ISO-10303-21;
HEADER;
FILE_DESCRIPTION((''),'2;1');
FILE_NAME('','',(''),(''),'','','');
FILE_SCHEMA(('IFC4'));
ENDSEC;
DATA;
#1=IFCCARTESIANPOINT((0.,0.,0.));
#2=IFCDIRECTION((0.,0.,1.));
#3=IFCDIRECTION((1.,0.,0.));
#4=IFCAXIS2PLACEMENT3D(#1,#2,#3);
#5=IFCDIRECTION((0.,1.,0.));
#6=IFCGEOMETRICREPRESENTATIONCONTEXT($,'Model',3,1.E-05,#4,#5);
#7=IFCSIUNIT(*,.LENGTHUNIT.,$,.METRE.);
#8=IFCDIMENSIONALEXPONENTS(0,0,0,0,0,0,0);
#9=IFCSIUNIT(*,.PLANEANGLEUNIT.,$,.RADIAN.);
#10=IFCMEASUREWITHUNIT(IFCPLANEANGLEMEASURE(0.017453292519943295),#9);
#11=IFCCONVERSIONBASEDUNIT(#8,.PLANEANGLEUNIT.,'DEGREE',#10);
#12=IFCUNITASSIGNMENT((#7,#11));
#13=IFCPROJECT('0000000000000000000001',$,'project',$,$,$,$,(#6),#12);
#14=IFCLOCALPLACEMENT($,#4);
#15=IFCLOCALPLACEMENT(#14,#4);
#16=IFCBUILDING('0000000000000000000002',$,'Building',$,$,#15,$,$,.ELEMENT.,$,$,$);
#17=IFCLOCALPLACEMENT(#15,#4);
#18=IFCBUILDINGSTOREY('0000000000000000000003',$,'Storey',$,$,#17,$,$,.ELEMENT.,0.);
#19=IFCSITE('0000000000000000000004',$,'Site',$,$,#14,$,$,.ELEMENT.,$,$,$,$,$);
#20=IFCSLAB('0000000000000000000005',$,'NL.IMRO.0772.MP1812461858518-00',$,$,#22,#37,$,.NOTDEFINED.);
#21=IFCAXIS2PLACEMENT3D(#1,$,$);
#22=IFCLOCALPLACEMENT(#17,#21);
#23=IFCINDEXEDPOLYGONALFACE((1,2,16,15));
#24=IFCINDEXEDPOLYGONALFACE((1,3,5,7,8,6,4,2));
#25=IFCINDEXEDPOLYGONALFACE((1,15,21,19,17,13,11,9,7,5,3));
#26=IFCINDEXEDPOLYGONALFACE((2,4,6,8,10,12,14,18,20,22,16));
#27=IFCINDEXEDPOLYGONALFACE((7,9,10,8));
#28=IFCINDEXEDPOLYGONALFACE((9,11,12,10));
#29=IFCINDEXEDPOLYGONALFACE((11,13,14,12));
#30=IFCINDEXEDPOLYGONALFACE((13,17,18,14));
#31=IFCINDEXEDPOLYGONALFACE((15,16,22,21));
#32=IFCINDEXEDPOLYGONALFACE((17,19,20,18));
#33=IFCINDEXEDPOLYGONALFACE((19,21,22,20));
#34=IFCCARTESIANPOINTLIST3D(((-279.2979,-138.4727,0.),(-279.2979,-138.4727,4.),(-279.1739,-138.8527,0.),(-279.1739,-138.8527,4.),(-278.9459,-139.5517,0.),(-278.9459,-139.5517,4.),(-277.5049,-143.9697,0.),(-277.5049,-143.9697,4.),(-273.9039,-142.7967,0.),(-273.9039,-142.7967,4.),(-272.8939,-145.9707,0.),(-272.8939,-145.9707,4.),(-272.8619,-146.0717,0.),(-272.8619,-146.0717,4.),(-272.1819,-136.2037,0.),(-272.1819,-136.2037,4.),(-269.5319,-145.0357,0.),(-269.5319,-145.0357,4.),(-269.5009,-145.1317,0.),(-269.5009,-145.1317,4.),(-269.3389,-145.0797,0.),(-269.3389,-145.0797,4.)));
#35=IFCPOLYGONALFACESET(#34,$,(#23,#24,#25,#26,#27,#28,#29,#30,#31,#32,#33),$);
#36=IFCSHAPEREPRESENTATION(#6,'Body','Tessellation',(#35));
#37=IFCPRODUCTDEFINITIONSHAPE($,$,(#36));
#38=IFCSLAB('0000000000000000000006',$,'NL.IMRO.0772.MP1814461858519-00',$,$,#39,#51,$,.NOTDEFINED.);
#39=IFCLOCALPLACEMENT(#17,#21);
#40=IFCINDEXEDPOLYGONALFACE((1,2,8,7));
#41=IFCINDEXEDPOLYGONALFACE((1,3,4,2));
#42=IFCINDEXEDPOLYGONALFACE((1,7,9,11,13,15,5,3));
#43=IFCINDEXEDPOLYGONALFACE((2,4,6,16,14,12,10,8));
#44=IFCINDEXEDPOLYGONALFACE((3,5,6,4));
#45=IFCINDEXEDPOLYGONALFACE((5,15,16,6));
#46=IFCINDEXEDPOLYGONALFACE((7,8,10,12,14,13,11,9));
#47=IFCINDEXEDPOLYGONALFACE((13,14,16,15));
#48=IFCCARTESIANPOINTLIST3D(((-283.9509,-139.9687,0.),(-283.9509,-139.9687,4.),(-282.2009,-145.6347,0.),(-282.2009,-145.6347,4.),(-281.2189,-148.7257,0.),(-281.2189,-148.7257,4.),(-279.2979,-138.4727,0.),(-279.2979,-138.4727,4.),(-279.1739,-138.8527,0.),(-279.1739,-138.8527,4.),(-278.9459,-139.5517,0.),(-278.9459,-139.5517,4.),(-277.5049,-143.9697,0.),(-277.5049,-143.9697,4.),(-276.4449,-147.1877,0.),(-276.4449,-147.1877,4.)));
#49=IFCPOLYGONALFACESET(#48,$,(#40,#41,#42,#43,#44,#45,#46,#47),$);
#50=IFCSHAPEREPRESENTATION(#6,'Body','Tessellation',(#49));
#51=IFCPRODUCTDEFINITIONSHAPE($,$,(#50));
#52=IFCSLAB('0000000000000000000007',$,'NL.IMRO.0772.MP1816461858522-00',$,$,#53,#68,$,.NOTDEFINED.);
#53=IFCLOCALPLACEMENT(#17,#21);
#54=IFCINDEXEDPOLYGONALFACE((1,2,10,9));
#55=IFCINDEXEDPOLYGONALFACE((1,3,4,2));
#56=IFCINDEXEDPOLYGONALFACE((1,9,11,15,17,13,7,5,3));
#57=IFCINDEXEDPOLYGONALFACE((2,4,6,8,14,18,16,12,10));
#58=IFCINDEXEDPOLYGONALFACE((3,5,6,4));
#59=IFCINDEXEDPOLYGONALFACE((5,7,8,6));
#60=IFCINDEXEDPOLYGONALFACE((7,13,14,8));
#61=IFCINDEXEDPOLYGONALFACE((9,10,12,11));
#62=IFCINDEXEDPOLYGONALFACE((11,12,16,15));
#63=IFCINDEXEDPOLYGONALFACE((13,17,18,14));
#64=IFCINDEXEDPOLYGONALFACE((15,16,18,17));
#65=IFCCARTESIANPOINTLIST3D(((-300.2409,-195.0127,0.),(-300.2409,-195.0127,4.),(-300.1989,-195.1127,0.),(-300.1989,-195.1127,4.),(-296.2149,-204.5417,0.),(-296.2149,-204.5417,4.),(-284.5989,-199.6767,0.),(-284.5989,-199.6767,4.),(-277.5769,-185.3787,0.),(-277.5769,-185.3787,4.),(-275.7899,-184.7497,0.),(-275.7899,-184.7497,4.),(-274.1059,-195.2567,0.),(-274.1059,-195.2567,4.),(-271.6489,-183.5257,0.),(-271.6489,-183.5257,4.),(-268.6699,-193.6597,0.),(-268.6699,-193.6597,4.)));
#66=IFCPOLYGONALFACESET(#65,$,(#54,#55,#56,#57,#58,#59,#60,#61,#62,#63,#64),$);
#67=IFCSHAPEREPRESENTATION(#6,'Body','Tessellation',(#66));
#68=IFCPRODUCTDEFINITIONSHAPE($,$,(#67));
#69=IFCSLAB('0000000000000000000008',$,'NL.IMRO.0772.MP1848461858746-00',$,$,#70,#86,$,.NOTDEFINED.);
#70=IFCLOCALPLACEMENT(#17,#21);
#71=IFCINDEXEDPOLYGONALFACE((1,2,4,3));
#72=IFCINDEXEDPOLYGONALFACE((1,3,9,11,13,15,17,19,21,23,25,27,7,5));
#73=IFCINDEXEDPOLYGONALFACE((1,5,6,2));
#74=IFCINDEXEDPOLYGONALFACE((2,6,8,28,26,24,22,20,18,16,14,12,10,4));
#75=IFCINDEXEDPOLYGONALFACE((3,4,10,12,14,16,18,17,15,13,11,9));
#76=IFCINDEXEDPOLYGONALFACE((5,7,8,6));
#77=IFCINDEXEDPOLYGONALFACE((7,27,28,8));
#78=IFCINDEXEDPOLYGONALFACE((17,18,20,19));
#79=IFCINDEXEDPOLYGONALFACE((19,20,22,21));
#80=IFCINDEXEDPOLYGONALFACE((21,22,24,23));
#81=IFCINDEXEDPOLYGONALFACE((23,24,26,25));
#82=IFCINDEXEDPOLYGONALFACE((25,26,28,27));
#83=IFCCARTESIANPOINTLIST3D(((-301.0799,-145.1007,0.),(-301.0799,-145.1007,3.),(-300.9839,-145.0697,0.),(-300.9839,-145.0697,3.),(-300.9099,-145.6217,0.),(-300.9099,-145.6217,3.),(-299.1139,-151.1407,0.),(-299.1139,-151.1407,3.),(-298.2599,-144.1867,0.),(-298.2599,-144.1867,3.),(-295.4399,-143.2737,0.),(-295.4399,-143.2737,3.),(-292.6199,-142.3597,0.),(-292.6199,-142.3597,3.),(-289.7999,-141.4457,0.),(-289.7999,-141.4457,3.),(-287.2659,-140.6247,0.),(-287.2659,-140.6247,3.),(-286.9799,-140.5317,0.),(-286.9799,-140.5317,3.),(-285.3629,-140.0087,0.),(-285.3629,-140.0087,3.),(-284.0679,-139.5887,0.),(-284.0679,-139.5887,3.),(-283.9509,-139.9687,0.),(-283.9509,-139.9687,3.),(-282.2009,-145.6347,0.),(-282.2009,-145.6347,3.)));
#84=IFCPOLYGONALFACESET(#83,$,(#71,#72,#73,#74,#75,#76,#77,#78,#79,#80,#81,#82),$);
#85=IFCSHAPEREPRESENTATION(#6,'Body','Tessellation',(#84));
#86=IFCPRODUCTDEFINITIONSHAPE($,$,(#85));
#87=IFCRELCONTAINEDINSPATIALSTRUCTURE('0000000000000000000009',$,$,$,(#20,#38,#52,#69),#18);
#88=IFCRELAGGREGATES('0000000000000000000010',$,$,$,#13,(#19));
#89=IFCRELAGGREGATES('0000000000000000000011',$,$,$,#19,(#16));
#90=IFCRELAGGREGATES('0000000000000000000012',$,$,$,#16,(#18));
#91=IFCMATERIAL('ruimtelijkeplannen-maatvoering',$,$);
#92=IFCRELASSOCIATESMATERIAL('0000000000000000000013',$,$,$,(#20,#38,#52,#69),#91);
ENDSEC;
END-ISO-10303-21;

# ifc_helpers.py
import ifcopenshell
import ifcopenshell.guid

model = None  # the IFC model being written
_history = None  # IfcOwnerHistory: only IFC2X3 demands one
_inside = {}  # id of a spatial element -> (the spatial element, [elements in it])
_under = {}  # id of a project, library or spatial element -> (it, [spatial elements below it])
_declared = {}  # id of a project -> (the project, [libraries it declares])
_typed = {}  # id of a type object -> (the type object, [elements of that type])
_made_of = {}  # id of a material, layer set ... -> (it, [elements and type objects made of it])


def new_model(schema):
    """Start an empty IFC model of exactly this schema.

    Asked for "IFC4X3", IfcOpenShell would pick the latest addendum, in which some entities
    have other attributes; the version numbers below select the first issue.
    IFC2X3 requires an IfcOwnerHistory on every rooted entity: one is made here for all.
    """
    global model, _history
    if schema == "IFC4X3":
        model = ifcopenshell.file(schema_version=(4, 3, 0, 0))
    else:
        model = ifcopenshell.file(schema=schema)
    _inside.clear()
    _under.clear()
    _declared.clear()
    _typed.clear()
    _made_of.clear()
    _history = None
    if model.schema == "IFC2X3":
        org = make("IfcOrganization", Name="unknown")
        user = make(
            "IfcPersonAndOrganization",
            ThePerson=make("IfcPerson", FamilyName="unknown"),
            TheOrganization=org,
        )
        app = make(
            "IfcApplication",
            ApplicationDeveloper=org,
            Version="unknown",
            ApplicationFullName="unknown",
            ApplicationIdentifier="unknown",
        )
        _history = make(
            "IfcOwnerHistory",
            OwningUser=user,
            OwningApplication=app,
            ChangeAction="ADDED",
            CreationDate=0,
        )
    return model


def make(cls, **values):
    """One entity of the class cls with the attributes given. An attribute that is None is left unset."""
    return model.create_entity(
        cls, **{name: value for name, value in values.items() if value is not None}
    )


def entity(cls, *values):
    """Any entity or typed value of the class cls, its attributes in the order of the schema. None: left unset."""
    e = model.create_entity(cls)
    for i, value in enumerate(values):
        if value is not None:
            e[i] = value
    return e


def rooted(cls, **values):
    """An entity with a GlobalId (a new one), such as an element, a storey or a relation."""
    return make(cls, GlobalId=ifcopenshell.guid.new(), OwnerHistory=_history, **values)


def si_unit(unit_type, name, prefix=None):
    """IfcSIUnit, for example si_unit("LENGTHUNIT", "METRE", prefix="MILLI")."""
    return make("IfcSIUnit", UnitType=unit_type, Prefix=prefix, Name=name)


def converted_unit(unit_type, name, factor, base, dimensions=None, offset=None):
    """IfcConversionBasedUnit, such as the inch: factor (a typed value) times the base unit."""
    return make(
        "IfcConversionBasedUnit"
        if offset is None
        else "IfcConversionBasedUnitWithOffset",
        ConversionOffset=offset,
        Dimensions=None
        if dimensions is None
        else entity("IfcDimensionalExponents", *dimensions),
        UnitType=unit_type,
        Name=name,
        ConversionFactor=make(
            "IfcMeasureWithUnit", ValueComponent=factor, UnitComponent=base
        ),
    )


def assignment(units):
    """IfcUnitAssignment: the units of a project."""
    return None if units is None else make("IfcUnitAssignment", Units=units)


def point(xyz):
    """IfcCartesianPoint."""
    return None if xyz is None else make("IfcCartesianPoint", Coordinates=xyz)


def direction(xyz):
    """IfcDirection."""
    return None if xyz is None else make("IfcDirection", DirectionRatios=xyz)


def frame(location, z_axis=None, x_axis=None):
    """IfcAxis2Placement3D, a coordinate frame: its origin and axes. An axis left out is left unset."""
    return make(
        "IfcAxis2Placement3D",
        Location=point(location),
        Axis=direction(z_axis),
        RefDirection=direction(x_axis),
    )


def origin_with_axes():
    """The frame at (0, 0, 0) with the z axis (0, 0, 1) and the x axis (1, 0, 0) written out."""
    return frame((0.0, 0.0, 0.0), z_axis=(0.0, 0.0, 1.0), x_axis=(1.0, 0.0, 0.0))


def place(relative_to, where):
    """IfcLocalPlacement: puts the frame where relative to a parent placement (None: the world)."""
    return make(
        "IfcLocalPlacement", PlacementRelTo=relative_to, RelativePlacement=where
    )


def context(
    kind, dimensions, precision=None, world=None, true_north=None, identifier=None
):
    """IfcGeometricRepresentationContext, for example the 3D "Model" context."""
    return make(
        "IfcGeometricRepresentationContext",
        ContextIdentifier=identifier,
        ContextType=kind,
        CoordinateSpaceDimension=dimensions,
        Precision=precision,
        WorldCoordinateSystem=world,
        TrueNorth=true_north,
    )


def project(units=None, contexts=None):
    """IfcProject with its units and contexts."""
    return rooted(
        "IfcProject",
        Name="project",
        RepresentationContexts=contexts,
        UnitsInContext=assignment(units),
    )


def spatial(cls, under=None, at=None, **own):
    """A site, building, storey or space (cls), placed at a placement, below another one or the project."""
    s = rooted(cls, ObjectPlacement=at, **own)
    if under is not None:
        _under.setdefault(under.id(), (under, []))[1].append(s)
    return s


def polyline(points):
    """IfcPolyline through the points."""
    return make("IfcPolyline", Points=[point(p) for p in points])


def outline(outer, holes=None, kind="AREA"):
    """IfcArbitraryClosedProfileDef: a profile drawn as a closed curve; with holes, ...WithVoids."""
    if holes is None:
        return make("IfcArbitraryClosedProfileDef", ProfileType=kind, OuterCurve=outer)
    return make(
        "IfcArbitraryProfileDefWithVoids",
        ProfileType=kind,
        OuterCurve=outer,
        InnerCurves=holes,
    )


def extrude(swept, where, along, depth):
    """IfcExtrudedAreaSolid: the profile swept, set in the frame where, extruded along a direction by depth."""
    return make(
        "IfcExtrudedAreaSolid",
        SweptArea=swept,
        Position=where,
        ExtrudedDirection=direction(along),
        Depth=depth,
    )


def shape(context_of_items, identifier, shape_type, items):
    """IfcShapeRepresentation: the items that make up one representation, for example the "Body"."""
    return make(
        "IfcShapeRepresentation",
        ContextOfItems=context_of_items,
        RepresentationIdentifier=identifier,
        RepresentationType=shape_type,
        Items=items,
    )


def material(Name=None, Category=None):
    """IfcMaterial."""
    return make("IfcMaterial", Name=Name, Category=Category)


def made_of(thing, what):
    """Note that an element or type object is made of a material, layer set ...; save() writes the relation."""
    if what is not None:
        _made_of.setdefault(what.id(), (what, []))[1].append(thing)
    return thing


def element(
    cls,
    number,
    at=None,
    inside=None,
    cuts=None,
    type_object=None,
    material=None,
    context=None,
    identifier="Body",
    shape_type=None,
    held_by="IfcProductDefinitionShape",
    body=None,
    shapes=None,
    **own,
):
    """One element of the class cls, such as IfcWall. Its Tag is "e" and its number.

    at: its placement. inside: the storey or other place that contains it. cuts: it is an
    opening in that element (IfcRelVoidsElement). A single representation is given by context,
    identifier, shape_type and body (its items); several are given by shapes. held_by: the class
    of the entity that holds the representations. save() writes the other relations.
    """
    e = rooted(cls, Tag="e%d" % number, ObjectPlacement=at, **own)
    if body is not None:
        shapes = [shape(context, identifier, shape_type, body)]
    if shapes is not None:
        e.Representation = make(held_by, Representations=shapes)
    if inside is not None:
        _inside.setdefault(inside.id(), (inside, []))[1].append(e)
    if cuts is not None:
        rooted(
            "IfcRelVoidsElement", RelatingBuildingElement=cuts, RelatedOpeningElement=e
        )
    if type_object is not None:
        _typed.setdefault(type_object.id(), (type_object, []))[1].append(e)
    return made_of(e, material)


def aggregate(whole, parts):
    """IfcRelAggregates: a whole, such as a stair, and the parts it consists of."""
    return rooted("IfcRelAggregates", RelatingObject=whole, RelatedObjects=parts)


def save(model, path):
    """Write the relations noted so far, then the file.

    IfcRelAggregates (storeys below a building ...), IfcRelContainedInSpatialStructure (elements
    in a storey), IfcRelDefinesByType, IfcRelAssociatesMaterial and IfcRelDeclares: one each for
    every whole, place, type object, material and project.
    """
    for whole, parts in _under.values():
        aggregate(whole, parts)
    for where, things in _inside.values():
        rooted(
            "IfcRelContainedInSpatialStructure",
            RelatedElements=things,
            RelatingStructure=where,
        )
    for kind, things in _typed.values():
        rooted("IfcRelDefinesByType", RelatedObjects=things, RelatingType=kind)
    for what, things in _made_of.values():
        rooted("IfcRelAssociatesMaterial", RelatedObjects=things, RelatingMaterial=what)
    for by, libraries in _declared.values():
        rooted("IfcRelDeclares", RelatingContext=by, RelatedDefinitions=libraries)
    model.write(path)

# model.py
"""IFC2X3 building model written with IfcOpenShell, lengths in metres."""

from ifc_helpers import new_model, entity, si_unit, converted_unit, direction, origin_with_axes, place, context, project, spatial, polyline, outline, extrude, material, element, save


model = new_model("IFC2X3")

# Units and contexts
model_context = context("Model", 3, precision=1e-05, world=origin_with_axes(), true_north=direction((0.0, 1.0, 0.0)))
ifc_project = project(units=[si_unit("LENGTHUNIT", "METRE"), converted_unit("PLANEANGLEUNIT", "DEGREE", entity("IfcPlaneAngleMeasure", 0.017453292519943295), si_unit("PLANEANGLEUNIT", "RADIAN"), dimensions=[0, 0, 0, 0, 0, 0, 0])], contexts=[model_context])

# Site, building, storey
site_placement = place(None, origin_with_axes())
site = spatial("IfcSite", under=ifc_project, at=site_placement, Name="Site", CompositionType="ELEMENT")
building_placement = place(site_placement, origin_with_axes())
building = spatial("IfcBuilding", under=site, at=building_placement, Name="Building", CompositionType="ELEMENT")
storey_placement = place(building_placement, origin_with_axes())
storey = spatial("IfcBuildingStorey", under=building, at=storey_placement, Name="Storey", CompositionType="ELEMENT", Elevation=0.0)

# Slabs
ifc_material = material(Name="ruimtelijkeplannen-maatvoering")
slab_1_placement = place(storey_placement, origin_with_axes())
element("IfcSlab", 1, at=slab_1_placement, inside=storey, material=ifc_material, Name="NL.IMRO.0772.MP1812461858518-00", PredefinedType="NOTDEFINED", context=model_context, shape_type="SweptSolid", body=[
    extrude(outline(polyline([(-272.8939, -145.9707), (-273.9039, -142.7967), (-277.5049, -143.9697), (-278.9459, -139.5517), (-279.1739, -138.8527), (-279.2979, -138.4727), (-272.1819, -136.2037), (-269.3389, -145.0797), (-269.5009, -145.1317), (-269.5319, -145.0357), (-272.8619, -146.0717), (-272.8939, -145.9707)])), origin_with_axes(), (0.0, 0.0, 1.0), 4.0),
])
slab_2_placement = place(storey_placement, origin_with_axes())
element("IfcSlab", 2, at=slab_2_placement, inside=storey, material=ifc_material, Name="NL.IMRO.0772.MP1814461858519-00", PredefinedType="NOTDEFINED", context=model_context, shape_type="SweptSolid", body=[
    extrude(outline(polyline([(-283.9509, -139.9687), (-279.2979, -138.4727), (-279.1739, -138.8527), (-278.9459, -139.5517), (-277.5049, -143.9697), (-276.4449, -147.1877), (-281.2189, -148.7257), (-282.2009, -145.6347), (-283.9509, -139.9687)])), origin_with_axes(), (0.0, 0.0, 1.0), 4.0),
])
slab_3_placement = place(storey_placement, origin_with_axes())
element("IfcSlab", 3, at=slab_3_placement, inside=storey, material=ifc_material, Name="NL.IMRO.0772.MP1816461858522-00", PredefinedType="NOTDEFINED", context=model_context, shape_type="SweptSolid", body=[
    extrude(outline(polyline([(-271.6489, -183.5257), (-268.6699, -193.6597), (-274.1059, -195.2567), (-284.5989, -199.6767), (-296.2149, -204.5417), (-300.1989, -195.1127), (-300.2409, -195.0127), (-277.5769, -185.3787), (-275.7899, -184.7497), (-271.6489, -183.5257)])), origin_with_axes(), (0.0, 0.0, 1.0), 4.0),
])
slab_4_placement = place(storey_placement, origin_with_axes())
element("IfcSlab", 4, at=slab_4_placement, inside=storey, material=ifc_material, Name="NL.IMRO.0772.MP1848461858746-00", PredefinedType="NOTDEFINED", context=model_context, shape_type="SweptSolid", body=[
    extrude(outline(polyline([(-299.1139, -151.1407), (-300.9099, -145.6217), (-301.0799, -145.1007), (-300.9839, -145.0697), (-298.2599, -144.1867), (-295.4399, -143.2737), (-292.6199, -142.3597), (-289.7999, -141.4457), (-287.2659, -140.6247), (-286.9799, -140.5317), (-285.3629, -140.0087), (-284.0679, -139.5887), (-283.9509, -139.9687), (-282.2009, -145.6347), (-299.1139, -151.1407)])), origin_with_axes(), (0.0, 0.0, 1.0), 3.0),
])

save(model, "model.ifc")
